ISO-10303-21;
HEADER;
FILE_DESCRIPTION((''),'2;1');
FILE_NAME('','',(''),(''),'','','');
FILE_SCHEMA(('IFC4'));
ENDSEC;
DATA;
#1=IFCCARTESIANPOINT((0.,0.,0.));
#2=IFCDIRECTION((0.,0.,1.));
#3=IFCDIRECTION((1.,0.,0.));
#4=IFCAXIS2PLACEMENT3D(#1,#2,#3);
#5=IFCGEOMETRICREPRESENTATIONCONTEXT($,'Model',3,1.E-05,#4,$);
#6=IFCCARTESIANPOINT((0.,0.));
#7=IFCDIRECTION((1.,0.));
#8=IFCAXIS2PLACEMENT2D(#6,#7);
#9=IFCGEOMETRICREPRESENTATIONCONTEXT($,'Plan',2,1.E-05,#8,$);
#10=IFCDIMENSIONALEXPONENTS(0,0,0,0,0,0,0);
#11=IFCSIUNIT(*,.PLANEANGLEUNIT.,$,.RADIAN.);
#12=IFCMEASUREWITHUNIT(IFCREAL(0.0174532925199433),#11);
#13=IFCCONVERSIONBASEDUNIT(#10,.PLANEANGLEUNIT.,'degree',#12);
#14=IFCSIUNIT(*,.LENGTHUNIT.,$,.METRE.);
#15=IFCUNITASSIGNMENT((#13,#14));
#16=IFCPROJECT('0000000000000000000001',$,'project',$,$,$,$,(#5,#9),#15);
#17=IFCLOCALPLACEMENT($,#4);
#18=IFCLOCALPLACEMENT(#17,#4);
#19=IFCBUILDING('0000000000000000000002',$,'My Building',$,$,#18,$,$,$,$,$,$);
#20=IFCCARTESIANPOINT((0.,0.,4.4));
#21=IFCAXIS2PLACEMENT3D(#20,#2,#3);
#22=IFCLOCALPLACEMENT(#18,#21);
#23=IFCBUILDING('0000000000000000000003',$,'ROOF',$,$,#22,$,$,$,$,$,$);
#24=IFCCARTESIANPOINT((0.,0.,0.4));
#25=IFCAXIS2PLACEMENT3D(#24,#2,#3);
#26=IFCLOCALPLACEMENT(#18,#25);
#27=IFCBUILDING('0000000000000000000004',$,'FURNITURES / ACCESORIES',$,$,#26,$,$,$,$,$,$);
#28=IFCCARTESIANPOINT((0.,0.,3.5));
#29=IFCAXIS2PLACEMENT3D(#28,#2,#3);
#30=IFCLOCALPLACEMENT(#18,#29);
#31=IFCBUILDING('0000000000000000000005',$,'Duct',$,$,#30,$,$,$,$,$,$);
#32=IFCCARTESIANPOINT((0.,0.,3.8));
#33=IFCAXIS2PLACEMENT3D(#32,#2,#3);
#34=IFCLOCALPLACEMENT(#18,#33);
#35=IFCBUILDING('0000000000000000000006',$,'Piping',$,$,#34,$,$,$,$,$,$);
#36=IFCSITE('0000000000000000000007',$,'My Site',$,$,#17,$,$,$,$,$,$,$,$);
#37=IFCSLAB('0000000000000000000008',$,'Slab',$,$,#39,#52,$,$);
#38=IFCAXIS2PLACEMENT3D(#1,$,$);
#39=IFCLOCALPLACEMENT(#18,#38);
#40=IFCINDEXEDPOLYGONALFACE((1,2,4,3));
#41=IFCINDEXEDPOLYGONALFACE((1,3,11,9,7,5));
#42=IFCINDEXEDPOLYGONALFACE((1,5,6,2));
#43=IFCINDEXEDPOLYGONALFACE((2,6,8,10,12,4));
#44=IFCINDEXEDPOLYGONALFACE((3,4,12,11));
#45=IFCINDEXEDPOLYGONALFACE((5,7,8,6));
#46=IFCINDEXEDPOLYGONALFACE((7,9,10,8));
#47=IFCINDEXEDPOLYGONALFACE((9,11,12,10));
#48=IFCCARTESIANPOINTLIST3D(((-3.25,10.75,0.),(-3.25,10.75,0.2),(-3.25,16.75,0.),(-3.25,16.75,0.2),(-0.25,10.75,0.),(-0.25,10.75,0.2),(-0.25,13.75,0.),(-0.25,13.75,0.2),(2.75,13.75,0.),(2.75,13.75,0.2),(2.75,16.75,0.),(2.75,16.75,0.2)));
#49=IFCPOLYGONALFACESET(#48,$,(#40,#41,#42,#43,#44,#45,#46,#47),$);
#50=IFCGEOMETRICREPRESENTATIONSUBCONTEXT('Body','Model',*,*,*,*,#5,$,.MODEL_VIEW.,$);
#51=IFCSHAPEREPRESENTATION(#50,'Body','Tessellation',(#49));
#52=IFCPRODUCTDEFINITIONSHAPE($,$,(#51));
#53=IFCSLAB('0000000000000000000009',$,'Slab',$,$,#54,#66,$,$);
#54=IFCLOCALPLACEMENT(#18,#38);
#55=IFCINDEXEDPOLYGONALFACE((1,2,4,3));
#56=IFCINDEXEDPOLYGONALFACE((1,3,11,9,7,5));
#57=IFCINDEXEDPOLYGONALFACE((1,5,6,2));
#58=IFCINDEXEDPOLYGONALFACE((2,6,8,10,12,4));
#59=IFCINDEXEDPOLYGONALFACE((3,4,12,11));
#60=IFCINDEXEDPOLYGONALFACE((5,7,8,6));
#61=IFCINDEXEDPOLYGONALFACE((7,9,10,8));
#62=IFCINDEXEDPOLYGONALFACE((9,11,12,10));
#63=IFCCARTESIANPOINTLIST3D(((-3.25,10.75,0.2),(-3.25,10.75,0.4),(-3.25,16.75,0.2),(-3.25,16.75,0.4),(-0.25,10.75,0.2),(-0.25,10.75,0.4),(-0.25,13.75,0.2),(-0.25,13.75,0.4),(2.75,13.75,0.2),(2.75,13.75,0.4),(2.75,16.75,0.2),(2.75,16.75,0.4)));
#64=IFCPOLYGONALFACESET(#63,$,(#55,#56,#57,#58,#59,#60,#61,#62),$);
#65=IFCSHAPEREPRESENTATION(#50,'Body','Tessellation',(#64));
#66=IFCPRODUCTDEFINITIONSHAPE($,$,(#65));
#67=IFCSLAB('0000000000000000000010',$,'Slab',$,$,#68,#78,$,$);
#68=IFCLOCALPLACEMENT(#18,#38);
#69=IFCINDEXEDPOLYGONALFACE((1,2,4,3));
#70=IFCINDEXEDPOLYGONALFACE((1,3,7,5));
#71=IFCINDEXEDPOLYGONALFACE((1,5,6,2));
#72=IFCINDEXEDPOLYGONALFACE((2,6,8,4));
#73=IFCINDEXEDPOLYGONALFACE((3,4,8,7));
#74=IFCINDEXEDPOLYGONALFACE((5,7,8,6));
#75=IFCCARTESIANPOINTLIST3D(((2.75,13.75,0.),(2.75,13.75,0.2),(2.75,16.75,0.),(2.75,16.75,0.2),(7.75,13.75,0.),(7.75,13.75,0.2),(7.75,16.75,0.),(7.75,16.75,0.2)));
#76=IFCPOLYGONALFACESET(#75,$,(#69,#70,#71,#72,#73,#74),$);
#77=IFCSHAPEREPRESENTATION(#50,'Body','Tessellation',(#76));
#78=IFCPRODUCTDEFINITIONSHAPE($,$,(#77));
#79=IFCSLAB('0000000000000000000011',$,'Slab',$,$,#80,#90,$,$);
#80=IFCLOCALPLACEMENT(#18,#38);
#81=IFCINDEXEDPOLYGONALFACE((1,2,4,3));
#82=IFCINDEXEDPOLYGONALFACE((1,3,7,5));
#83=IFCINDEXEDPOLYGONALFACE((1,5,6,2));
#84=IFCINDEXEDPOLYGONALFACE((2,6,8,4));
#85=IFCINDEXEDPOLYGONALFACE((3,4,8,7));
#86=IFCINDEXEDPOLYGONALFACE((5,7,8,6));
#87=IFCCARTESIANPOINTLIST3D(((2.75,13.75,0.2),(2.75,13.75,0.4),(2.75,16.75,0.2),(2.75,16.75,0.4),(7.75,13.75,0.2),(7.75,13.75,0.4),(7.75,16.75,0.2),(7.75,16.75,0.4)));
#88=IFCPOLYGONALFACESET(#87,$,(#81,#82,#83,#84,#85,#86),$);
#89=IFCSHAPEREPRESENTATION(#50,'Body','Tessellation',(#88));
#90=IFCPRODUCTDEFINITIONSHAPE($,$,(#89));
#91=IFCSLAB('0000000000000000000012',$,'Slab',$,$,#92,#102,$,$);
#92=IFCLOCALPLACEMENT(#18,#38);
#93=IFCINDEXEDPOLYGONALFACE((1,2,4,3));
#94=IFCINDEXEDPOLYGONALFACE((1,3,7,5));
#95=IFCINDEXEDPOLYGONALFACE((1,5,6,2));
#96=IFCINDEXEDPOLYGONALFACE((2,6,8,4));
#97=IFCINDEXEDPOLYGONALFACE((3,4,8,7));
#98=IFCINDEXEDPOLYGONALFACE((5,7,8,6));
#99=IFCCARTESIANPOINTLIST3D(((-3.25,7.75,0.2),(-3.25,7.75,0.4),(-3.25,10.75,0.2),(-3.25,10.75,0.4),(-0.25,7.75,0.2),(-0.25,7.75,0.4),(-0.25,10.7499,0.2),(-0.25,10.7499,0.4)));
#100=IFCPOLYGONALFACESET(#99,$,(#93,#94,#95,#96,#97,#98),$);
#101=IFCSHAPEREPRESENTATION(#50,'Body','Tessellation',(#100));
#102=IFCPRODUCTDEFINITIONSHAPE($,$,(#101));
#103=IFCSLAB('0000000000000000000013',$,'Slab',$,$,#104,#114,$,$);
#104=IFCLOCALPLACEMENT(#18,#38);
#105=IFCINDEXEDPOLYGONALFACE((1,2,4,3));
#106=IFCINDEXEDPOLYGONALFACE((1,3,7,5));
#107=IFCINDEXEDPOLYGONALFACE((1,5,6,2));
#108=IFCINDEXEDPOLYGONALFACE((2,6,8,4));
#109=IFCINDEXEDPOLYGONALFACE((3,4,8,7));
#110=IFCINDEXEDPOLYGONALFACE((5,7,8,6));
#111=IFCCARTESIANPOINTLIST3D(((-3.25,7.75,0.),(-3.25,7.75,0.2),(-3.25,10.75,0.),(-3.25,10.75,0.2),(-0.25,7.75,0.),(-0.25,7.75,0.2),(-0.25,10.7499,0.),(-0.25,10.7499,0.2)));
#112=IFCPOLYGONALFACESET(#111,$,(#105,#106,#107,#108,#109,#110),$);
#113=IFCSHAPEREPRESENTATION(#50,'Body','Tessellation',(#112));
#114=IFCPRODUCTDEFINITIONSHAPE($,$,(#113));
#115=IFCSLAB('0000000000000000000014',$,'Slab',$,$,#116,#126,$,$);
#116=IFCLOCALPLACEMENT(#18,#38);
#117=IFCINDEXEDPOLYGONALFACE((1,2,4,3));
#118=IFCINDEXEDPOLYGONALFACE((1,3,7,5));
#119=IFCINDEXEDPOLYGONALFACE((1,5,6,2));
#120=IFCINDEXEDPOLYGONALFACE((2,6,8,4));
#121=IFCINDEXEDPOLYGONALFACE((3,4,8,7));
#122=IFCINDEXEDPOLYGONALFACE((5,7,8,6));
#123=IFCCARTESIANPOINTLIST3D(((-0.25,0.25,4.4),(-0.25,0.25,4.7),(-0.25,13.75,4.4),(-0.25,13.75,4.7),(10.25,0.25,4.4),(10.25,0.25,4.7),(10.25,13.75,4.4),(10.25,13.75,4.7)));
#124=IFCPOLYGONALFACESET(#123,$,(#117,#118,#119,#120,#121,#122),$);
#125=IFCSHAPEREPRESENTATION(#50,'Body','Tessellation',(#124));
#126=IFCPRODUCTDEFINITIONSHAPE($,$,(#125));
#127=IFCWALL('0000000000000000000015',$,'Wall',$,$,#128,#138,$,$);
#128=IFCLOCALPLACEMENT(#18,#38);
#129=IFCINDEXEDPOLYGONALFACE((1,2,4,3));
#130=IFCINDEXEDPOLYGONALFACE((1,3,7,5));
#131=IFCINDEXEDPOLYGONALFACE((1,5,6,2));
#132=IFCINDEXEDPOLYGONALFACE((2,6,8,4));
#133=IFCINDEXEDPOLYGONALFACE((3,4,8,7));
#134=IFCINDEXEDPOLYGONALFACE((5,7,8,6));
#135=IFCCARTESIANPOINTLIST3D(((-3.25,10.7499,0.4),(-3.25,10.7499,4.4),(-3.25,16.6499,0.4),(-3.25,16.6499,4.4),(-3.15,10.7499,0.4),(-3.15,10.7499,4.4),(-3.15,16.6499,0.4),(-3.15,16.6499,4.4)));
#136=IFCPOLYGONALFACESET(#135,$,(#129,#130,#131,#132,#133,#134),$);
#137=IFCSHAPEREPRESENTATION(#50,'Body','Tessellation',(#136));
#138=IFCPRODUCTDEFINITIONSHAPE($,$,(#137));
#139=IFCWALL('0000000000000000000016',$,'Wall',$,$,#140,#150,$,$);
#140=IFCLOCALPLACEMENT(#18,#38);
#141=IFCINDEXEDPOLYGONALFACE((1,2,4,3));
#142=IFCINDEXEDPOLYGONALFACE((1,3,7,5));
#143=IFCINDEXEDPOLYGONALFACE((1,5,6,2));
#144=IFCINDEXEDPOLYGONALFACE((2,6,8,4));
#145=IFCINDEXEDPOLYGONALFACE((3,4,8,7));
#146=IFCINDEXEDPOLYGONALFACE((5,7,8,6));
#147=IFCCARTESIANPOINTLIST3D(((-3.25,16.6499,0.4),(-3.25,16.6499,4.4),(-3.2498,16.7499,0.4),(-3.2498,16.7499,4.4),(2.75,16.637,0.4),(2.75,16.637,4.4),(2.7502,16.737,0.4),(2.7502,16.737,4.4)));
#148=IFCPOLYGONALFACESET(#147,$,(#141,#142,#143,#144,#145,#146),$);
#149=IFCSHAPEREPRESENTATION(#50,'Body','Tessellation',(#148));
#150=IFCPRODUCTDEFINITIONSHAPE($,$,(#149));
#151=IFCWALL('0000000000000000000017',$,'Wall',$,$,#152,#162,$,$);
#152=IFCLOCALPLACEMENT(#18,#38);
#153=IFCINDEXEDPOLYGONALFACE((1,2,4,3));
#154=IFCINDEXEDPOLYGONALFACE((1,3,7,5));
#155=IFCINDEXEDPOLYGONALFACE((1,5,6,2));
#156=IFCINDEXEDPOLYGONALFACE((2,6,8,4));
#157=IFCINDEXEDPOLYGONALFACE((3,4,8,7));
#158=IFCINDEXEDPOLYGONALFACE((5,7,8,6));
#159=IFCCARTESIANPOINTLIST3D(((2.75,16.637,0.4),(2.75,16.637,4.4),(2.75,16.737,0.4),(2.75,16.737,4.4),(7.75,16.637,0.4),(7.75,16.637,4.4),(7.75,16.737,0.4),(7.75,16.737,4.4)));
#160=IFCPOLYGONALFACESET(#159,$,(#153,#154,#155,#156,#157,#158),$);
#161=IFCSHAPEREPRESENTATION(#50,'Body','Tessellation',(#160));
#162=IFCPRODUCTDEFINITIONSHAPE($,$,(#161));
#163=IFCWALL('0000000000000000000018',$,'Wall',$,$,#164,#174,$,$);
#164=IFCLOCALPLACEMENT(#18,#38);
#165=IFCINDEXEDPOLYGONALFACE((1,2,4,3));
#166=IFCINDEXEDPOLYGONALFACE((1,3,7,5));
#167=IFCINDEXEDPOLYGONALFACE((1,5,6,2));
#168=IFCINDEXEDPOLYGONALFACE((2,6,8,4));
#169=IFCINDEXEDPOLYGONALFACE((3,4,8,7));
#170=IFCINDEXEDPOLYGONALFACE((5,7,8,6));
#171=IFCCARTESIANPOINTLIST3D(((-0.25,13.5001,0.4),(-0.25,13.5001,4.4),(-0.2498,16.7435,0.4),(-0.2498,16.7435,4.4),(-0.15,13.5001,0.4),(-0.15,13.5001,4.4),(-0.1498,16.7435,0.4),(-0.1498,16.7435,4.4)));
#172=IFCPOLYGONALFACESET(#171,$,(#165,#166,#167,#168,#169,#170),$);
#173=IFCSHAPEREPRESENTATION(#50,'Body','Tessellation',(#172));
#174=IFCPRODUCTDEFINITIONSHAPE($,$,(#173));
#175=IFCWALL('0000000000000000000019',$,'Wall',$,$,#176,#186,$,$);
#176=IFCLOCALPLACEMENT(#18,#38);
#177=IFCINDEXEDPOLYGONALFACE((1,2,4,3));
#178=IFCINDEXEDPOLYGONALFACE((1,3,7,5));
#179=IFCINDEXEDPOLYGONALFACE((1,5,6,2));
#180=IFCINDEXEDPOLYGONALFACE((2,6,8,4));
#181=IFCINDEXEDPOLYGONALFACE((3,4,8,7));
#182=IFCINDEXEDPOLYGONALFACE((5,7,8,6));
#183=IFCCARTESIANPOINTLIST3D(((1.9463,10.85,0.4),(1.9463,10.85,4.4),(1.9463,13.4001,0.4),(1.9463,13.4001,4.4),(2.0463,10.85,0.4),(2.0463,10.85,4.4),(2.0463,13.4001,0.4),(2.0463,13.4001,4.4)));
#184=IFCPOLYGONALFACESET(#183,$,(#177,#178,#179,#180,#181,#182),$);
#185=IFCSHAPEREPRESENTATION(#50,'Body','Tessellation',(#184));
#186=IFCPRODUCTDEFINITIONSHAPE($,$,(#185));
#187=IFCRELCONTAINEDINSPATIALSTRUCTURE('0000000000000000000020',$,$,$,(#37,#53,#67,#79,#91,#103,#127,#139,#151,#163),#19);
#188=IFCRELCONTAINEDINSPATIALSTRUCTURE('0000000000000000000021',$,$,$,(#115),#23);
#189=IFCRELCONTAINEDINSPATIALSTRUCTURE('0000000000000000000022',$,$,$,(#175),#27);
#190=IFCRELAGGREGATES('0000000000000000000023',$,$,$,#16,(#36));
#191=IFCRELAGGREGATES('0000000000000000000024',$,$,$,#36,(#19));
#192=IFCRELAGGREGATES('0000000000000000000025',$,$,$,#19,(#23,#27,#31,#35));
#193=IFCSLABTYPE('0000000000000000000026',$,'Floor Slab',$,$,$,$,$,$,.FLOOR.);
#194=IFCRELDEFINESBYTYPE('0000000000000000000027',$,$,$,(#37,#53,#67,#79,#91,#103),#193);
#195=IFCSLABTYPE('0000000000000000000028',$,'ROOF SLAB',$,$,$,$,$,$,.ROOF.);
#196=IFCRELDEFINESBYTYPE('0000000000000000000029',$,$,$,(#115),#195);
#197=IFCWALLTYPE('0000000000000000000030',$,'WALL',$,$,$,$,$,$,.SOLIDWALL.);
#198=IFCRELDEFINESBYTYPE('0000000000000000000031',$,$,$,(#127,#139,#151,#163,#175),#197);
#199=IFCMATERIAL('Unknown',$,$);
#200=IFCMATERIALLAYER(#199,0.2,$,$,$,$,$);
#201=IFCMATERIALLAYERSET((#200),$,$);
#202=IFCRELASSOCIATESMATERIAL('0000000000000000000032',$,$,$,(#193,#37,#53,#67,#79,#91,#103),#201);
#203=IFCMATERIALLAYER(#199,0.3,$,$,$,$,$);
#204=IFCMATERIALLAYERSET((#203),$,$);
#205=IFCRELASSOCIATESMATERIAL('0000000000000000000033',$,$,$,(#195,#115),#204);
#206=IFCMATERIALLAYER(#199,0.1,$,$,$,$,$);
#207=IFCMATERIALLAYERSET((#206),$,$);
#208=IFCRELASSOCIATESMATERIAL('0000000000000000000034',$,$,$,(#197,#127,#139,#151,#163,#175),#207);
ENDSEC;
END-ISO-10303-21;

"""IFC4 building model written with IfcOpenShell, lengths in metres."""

from ifc_helpers import new_model, entity, si_unit, converted_unit, frame, origin_with_axes, origin_2d_with_axis, place, context, subcontext, project, spatial, line, indexed_curve, outline, extrude, material, layer, layer_set, layer_usage, type_object, element, save


model = new_model("IFC4")

# Units and contexts
model_context = context("Model", 3, precision=1e-05, world=origin_with_axes())
plan_context = context("Plan", 2, precision=1e-05, world=origin_2d_with_axis())
body_context_1 = subcontext(model_context, "Body", "Model", "MODEL_VIEW")
ifc_project = project(units=[converted_unit("PLANEANGLEUNIT", "degree", entity("IfcReal", 0.0174532925199433), si_unit("PLANEANGLEUNIT", "RADIAN"), dimensions=[0, 0, 0, 0, 0, 0, 0]), si_unit("LENGTHUNIT", "METRE")], contexts=[model_context, plan_context])

# Site, building
site_placement = place(None, origin_with_axes())
site = spatial("IfcSite", under=ifc_project, at=site_placement, Name="My Site")
building_1_placement = place(site_placement, origin_with_axes())
building_1 = spatial("IfcBuilding", under=site, at=building_1_placement, Name="My Building")

# Slabs
ifc_material = material(Name="Unknown")
ifc_layer_1 = layer(ifc_material, 0.2)
ifc_layer_set_1 = layer_set([ifc_layer_1])
ifc_layer_usage_1 = layer_usage(ifc_layer_set_1, "AXIS3", "POSITIVE", 0.0)
slab_type_1 = type_object("IfcSlabType", Name="Floor Slab", PredefinedType="FLOOR", material=ifc_layer_set_1)
slab_1_placement = place(building_1_placement, frame((-0.25, 13.75, 0.0), z_axis=(0.0, 0.0, 1.0), x_axis=(1.0, 0.0, 0.0)))
element("IfcSlab", 1, at=slab_1_placement, inside=building_1, type_object=slab_type_1, material=ifc_layer_usage_1, Name="Slab", context=body_context_1, shape_type="SweptSolid", body=[
    extrude(outline(indexed_curve([(0.0, 0.0), (3.0, 0.0), (3.0, 3.0), (-3.0, 3.0), (-3.0, -3.0), (0.0, -3.0), (0.0, 0.0)])), None, (0.0, 0.0, 1.0), 0.2),
])
ifc_layer_usage_2 = layer_usage(ifc_layer_set_1, "AXIS3", "POSITIVE", 0.0)
slab_2_placement = place(building_1_placement, frame((-0.25, 13.75, 0.2), z_axis=(0.0, 0.0, 1.0), x_axis=(1.0, 0.0, 0.0)))
element("IfcSlab", 2, at=slab_2_placement, inside=building_1, type_object=slab_type_1, material=ifc_layer_usage_2, Name="Slab", context=body_context_1, shape_type="SweptSolid", body=[
    extrude(outline(indexed_curve([(0.0, 0.0), (3.0, 0.0), (3.0, 3.0), (-3.0, 3.0), (-3.0, -3.0), (0.0, -3.0), (0.0, 0.0)])), None, (0.0, 0.0, 1.0), 0.2),
])
ifc_layer_usage_3 = layer_usage(ifc_layer_set_1, "AXIS3", "POSITIVE", 0.0)
slab_3_placement = place(building_1_placement, frame((2.75, 16.75, 0.0), z_axis=(0.0, 0.0, 1.0), x_axis=(1.0, 0.0, 0.0)))
element("IfcSlab", 3, at=slab_3_placement, inside=building_1, type_object=slab_type_1, material=ifc_layer_usage_3, Name="Slab", context=body_context_1, shape_type="SweptSolid", body=[
    extrude(outline(indexed_curve([(0.0, 0.0), (5.0, 0.0), (5.0, -3.0), (0.0, -3.0), (0.0, 0.0)])), None, (0.0, 0.0, 1.0), 0.2),
])
ifc_layer_usage_4 = layer_usage(ifc_layer_set_1, "AXIS3", "POSITIVE", 0.0)
slab_4_placement = place(building_1_placement, frame((2.75, 16.75, 0.2), z_axis=(0.0, 0.0, 1.0), x_axis=(1.0, 0.0, 0.0)))
element("IfcSlab", 4, at=slab_4_placement, inside=building_1, type_object=slab_type_1, material=ifc_layer_usage_4, Name="Slab", context=body_context_1, shape_type="SweptSolid", body=[
    extrude(outline(indexed_curve([(0.0, 0.0), (5.0, 0.0), (5.0, -3.0), (0.0, -3.0), (0.0, 0.0)])), None, (0.0, 0.0, 1.0), 0.2),
])
ifc_layer_usage_5 = layer_usage(ifc_layer_set_1, "AXIS3", "POSITIVE", -0.2)
slab_5_placement = place(building_1_placement, frame((-3.25, 10.75, 0.4), z_axis=(0.0, 0.0, 1.0), x_axis=(1.0, 0.0, 0.0)))
element("IfcSlab", 5, at=slab_5_placement, inside=building_1, type_object=slab_type_1, material=ifc_layer_usage_5, Name="Slab", context=body_context_1, shape_type="SweptSolid", body=[
    extrude(outline(indexed_curve([(0.0, 0.0), (0.0, -3.0), (3.0, -3.0), (3.0, -0.0001), (0.0, 0.0)])), frame((0.0, 0.0, -0.2), z_axis=(0.0, 0.0, 1.0), x_axis=(1.0, 0.0, 0.0)), (0.0, 0.0, 1.0), 0.2),
])
ifc_layer_usage_6 = layer_usage(ifc_layer_set_1, "AXIS3", "POSITIVE", -0.2)
slab_6_placement = place(building_1_placement, frame((-3.25, 10.75, 0.2), z_axis=(0.0, 0.0, 1.0), x_axis=(1.0, 0.0, 0.0)))
element("IfcSlab", 6, at=slab_6_placement, inside=building_1, type_object=slab_type_1, material=ifc_layer_usage_6, Name="Slab", context=body_context_1, shape_type="SweptSolid", body=[
    extrude(outline(indexed_curve([(0.0, 0.0), (0.0, -3.0), (3.0, -3.0), (3.0, -0.0001), (0.0, 0.0)])), frame((0.0, 0.0, -0.2), z_axis=(0.0, 0.0, 1.0), x_axis=(1.0, 0.0, 0.0)), (0.0, 0.0, 1.0), 0.2),
])

# Shared definitions
building_2_placement = place(building_1_placement, frame((0.0, 0.0, 4.4), z_axis=(0.0, 0.0, 1.0), x_axis=(1.0, 0.0, 0.0)))
building_2 = spatial("IfcBuilding", under=building_1, at=building_2_placement, Name="ROOF")

# Slab
ifc_layer_2 = layer(ifc_material, 0.3)
ifc_layer_set_2 = layer_set([ifc_layer_2])
ifc_layer_usage_7 = layer_usage(ifc_layer_set_2, "AXIS3", "POSITIVE", 0.0)
slab_type_2 = type_object("IfcSlabType", Name="ROOF SLAB", PredefinedType="ROOF", material=ifc_layer_set_2)
slab_7_placement = place(building_2_placement, frame((-0.25, 13.75, 0.0), z_axis=(0.0, 0.0, 1.0), x_axis=(1.0, 0.0, 0.0)))
element("IfcSlab", 7, at=slab_7_placement, inside=building_2, type_object=slab_type_2, material=ifc_layer_usage_7, Name="Slab", context=body_context_1, shape_type="SweptSolid", body=[
    extrude(outline(indexed_curve([(0.0, 0.0), (10.5, 0.0), (10.5, -13.5), (0.0, -13.5), (0.0, 0.0)])), None, (0.0, 0.0, 1.0), 0.3),
])

# Walls
ifc_layer_3 = layer(ifc_material, 0.1)
ifc_layer_set_3 = layer_set([ifc_layer_3])
ifc_layer_usage_8 = layer_usage(ifc_layer_set_3, "AXIS2", "POSITIVE", 0.0)
wall_type_1 = type_object("IfcWallType", Name="WALL", PredefinedType="SOLIDWALL", material=ifc_layer_set_3)
wall_1_placement = place(building_1_placement, frame((-3.15, 10.7499, 0.4), z_axis=(0.0, 0.0, 1.0), x_axis=(0.0, 1.0, 0.0)))
element("IfcWall", 8, at=wall_1_placement, inside=building_1, type_object=wall_type_1, material=ifc_layer_usage_8, Name="Wall", context=body_context_1, shape_type="SweptSolid", body=[
    extrude(outline(indexed_curve([(0.0, 0.0), (0.0, 0.1), (5.9, 0.1), (5.9, 0.0)], segments=[line(1, 2, 3, 4, 1)])), origin_with_axes(), (0.0, 0.0, 1.0), 4.0),
])
ifc_layer_usage_9 = layer_usage(ifc_layer_set_3, "AXIS2", "POSITIVE", 0.0)
wall_2_placement = place(building_1_placement, frame((-3.25, 16.6499, 0.4), z_axis=(0.0, 0.0, 1.0), x_axis=(0.999998, -0.002154, 0.0)))
element("IfcWall", 9, at=wall_2_placement, inside=building_1, type_object=wall_type_1, material=ifc_layer_usage_9, Name="Wall", context=body_context_1, shape_type="SweptSolid", body=[
    extrude(outline(indexed_curve([(0.0, 0.0), (0.0, 0.1), (6.0, 0.1), (6.0, 0.0)], segments=[line(1, 2, 3, 4, 1)])), origin_with_axes(), (0.0, 0.0, 1.0), 4.0),
])
ifc_layer_usage_10 = layer_usage(ifc_layer_set_3, "AXIS2", "POSITIVE", 0.0)
wall_3_placement = place(building_1_placement, frame((2.75, 16.637, 0.4), z_axis=(0.0, 0.0, 1.0), x_axis=(1.0, 0.0, 0.0)))
element("IfcWall", 10, at=wall_3_placement, inside=building_1, type_object=wall_type_1, material=ifc_layer_usage_10, Name="Wall", context=body_context_1, shape_type="SweptSolid", body=[
    extrude(outline(indexed_curve([(0.0, 0.0), (0.0, 0.1), (5.0, 0.1), (5.0, 0.0)], segments=[line(1, 2, 3, 4, 1)])), origin_with_axes(), (0.0, 0.0, 1.0), 4.0),
])
ifc_layer_usage_11 = layer_usage(ifc_layer_set_3, "AXIS2", "POSITIVE", 0.0)
wall_4_placement = place(building_1_placement, frame((-0.15, 13.5001, 0.4), z_axis=(0.0, 0.0, 1.0), x_axis=(0.000067, 1.0, 0.0)))
element("IfcWall", 11, at=wall_4_placement, inside=building_1, type_object=wall_type_1, material=ifc_layer_usage_11, Name="Wall", context=body_context_1, shape_type="SweptSolid", body=[
    extrude(outline(indexed_curve([(0.0, 0.0), (0.0, 0.1), (3.2434, 0.1), (3.2434, 0.0)], segments=[line(1, 2, 3, 4, 1)])), origin_with_axes(), (0.0, 0.0, 1.0), 4.0),
])

# Shared definitions
building_3_placement = place(building_1_placement, frame((0.0, 0.0, 0.4), z_axis=(0.0, 0.0, 1.0), x_axis=(1.0, 0.0, 0.0)))
building_3 = spatial("IfcBuilding", under=building_1, at=building_3_placement, Name="FURNITURES / ACCESORIES")

# Wall
ifc_layer_usage_12 = layer_usage(ifc_layer_set_3, "AXIS2", "POSITIVE", 0.0)
wall_5_placement = place(building_3_placement, frame((1.9463, 13.4001, 0.0), z_axis=(0.0, 0.0, 1.0), x_axis=(0.0, -1.0, 0.0)))
element("IfcWall", 12, at=wall_5_placement, inside=building_3, type_object=wall_type_1, material=ifc_layer_usage_12, Name="Wall", context=body_context_1, shape_type="SweptSolid", body=[
    extrude(outline(indexed_curve([(0.0, 0.0), (0.0, 0.1), (2.5501, 0.1), (2.5501, 0.0)], segments=[line(1, 2, 3, 4, 1)])), origin_with_axes(), (0.0, 0.0, 1.0), 4.0),
])

# Shared definitions
building_4_placement = place(building_1_placement, frame((0.0, 0.0, 3.5), z_axis=(0.0, 0.0, 1.0), x_axis=(1.0, 0.0, 0.0)))
building_4 = spatial("IfcBuilding", under=building_1, at=building_4_placement, Name="Duct")

# Shared definitions
building_5_placement = place(building_1_placement, frame((0.0, 0.0, 3.8), z_axis=(0.0, 0.0, 1.0), x_axis=(1.0, 0.0, 0.0)))
building_5 = spatial("IfcBuilding", under=building_1, at=building_5_placement, Name="Piping")

save(model, "model.ifc")
